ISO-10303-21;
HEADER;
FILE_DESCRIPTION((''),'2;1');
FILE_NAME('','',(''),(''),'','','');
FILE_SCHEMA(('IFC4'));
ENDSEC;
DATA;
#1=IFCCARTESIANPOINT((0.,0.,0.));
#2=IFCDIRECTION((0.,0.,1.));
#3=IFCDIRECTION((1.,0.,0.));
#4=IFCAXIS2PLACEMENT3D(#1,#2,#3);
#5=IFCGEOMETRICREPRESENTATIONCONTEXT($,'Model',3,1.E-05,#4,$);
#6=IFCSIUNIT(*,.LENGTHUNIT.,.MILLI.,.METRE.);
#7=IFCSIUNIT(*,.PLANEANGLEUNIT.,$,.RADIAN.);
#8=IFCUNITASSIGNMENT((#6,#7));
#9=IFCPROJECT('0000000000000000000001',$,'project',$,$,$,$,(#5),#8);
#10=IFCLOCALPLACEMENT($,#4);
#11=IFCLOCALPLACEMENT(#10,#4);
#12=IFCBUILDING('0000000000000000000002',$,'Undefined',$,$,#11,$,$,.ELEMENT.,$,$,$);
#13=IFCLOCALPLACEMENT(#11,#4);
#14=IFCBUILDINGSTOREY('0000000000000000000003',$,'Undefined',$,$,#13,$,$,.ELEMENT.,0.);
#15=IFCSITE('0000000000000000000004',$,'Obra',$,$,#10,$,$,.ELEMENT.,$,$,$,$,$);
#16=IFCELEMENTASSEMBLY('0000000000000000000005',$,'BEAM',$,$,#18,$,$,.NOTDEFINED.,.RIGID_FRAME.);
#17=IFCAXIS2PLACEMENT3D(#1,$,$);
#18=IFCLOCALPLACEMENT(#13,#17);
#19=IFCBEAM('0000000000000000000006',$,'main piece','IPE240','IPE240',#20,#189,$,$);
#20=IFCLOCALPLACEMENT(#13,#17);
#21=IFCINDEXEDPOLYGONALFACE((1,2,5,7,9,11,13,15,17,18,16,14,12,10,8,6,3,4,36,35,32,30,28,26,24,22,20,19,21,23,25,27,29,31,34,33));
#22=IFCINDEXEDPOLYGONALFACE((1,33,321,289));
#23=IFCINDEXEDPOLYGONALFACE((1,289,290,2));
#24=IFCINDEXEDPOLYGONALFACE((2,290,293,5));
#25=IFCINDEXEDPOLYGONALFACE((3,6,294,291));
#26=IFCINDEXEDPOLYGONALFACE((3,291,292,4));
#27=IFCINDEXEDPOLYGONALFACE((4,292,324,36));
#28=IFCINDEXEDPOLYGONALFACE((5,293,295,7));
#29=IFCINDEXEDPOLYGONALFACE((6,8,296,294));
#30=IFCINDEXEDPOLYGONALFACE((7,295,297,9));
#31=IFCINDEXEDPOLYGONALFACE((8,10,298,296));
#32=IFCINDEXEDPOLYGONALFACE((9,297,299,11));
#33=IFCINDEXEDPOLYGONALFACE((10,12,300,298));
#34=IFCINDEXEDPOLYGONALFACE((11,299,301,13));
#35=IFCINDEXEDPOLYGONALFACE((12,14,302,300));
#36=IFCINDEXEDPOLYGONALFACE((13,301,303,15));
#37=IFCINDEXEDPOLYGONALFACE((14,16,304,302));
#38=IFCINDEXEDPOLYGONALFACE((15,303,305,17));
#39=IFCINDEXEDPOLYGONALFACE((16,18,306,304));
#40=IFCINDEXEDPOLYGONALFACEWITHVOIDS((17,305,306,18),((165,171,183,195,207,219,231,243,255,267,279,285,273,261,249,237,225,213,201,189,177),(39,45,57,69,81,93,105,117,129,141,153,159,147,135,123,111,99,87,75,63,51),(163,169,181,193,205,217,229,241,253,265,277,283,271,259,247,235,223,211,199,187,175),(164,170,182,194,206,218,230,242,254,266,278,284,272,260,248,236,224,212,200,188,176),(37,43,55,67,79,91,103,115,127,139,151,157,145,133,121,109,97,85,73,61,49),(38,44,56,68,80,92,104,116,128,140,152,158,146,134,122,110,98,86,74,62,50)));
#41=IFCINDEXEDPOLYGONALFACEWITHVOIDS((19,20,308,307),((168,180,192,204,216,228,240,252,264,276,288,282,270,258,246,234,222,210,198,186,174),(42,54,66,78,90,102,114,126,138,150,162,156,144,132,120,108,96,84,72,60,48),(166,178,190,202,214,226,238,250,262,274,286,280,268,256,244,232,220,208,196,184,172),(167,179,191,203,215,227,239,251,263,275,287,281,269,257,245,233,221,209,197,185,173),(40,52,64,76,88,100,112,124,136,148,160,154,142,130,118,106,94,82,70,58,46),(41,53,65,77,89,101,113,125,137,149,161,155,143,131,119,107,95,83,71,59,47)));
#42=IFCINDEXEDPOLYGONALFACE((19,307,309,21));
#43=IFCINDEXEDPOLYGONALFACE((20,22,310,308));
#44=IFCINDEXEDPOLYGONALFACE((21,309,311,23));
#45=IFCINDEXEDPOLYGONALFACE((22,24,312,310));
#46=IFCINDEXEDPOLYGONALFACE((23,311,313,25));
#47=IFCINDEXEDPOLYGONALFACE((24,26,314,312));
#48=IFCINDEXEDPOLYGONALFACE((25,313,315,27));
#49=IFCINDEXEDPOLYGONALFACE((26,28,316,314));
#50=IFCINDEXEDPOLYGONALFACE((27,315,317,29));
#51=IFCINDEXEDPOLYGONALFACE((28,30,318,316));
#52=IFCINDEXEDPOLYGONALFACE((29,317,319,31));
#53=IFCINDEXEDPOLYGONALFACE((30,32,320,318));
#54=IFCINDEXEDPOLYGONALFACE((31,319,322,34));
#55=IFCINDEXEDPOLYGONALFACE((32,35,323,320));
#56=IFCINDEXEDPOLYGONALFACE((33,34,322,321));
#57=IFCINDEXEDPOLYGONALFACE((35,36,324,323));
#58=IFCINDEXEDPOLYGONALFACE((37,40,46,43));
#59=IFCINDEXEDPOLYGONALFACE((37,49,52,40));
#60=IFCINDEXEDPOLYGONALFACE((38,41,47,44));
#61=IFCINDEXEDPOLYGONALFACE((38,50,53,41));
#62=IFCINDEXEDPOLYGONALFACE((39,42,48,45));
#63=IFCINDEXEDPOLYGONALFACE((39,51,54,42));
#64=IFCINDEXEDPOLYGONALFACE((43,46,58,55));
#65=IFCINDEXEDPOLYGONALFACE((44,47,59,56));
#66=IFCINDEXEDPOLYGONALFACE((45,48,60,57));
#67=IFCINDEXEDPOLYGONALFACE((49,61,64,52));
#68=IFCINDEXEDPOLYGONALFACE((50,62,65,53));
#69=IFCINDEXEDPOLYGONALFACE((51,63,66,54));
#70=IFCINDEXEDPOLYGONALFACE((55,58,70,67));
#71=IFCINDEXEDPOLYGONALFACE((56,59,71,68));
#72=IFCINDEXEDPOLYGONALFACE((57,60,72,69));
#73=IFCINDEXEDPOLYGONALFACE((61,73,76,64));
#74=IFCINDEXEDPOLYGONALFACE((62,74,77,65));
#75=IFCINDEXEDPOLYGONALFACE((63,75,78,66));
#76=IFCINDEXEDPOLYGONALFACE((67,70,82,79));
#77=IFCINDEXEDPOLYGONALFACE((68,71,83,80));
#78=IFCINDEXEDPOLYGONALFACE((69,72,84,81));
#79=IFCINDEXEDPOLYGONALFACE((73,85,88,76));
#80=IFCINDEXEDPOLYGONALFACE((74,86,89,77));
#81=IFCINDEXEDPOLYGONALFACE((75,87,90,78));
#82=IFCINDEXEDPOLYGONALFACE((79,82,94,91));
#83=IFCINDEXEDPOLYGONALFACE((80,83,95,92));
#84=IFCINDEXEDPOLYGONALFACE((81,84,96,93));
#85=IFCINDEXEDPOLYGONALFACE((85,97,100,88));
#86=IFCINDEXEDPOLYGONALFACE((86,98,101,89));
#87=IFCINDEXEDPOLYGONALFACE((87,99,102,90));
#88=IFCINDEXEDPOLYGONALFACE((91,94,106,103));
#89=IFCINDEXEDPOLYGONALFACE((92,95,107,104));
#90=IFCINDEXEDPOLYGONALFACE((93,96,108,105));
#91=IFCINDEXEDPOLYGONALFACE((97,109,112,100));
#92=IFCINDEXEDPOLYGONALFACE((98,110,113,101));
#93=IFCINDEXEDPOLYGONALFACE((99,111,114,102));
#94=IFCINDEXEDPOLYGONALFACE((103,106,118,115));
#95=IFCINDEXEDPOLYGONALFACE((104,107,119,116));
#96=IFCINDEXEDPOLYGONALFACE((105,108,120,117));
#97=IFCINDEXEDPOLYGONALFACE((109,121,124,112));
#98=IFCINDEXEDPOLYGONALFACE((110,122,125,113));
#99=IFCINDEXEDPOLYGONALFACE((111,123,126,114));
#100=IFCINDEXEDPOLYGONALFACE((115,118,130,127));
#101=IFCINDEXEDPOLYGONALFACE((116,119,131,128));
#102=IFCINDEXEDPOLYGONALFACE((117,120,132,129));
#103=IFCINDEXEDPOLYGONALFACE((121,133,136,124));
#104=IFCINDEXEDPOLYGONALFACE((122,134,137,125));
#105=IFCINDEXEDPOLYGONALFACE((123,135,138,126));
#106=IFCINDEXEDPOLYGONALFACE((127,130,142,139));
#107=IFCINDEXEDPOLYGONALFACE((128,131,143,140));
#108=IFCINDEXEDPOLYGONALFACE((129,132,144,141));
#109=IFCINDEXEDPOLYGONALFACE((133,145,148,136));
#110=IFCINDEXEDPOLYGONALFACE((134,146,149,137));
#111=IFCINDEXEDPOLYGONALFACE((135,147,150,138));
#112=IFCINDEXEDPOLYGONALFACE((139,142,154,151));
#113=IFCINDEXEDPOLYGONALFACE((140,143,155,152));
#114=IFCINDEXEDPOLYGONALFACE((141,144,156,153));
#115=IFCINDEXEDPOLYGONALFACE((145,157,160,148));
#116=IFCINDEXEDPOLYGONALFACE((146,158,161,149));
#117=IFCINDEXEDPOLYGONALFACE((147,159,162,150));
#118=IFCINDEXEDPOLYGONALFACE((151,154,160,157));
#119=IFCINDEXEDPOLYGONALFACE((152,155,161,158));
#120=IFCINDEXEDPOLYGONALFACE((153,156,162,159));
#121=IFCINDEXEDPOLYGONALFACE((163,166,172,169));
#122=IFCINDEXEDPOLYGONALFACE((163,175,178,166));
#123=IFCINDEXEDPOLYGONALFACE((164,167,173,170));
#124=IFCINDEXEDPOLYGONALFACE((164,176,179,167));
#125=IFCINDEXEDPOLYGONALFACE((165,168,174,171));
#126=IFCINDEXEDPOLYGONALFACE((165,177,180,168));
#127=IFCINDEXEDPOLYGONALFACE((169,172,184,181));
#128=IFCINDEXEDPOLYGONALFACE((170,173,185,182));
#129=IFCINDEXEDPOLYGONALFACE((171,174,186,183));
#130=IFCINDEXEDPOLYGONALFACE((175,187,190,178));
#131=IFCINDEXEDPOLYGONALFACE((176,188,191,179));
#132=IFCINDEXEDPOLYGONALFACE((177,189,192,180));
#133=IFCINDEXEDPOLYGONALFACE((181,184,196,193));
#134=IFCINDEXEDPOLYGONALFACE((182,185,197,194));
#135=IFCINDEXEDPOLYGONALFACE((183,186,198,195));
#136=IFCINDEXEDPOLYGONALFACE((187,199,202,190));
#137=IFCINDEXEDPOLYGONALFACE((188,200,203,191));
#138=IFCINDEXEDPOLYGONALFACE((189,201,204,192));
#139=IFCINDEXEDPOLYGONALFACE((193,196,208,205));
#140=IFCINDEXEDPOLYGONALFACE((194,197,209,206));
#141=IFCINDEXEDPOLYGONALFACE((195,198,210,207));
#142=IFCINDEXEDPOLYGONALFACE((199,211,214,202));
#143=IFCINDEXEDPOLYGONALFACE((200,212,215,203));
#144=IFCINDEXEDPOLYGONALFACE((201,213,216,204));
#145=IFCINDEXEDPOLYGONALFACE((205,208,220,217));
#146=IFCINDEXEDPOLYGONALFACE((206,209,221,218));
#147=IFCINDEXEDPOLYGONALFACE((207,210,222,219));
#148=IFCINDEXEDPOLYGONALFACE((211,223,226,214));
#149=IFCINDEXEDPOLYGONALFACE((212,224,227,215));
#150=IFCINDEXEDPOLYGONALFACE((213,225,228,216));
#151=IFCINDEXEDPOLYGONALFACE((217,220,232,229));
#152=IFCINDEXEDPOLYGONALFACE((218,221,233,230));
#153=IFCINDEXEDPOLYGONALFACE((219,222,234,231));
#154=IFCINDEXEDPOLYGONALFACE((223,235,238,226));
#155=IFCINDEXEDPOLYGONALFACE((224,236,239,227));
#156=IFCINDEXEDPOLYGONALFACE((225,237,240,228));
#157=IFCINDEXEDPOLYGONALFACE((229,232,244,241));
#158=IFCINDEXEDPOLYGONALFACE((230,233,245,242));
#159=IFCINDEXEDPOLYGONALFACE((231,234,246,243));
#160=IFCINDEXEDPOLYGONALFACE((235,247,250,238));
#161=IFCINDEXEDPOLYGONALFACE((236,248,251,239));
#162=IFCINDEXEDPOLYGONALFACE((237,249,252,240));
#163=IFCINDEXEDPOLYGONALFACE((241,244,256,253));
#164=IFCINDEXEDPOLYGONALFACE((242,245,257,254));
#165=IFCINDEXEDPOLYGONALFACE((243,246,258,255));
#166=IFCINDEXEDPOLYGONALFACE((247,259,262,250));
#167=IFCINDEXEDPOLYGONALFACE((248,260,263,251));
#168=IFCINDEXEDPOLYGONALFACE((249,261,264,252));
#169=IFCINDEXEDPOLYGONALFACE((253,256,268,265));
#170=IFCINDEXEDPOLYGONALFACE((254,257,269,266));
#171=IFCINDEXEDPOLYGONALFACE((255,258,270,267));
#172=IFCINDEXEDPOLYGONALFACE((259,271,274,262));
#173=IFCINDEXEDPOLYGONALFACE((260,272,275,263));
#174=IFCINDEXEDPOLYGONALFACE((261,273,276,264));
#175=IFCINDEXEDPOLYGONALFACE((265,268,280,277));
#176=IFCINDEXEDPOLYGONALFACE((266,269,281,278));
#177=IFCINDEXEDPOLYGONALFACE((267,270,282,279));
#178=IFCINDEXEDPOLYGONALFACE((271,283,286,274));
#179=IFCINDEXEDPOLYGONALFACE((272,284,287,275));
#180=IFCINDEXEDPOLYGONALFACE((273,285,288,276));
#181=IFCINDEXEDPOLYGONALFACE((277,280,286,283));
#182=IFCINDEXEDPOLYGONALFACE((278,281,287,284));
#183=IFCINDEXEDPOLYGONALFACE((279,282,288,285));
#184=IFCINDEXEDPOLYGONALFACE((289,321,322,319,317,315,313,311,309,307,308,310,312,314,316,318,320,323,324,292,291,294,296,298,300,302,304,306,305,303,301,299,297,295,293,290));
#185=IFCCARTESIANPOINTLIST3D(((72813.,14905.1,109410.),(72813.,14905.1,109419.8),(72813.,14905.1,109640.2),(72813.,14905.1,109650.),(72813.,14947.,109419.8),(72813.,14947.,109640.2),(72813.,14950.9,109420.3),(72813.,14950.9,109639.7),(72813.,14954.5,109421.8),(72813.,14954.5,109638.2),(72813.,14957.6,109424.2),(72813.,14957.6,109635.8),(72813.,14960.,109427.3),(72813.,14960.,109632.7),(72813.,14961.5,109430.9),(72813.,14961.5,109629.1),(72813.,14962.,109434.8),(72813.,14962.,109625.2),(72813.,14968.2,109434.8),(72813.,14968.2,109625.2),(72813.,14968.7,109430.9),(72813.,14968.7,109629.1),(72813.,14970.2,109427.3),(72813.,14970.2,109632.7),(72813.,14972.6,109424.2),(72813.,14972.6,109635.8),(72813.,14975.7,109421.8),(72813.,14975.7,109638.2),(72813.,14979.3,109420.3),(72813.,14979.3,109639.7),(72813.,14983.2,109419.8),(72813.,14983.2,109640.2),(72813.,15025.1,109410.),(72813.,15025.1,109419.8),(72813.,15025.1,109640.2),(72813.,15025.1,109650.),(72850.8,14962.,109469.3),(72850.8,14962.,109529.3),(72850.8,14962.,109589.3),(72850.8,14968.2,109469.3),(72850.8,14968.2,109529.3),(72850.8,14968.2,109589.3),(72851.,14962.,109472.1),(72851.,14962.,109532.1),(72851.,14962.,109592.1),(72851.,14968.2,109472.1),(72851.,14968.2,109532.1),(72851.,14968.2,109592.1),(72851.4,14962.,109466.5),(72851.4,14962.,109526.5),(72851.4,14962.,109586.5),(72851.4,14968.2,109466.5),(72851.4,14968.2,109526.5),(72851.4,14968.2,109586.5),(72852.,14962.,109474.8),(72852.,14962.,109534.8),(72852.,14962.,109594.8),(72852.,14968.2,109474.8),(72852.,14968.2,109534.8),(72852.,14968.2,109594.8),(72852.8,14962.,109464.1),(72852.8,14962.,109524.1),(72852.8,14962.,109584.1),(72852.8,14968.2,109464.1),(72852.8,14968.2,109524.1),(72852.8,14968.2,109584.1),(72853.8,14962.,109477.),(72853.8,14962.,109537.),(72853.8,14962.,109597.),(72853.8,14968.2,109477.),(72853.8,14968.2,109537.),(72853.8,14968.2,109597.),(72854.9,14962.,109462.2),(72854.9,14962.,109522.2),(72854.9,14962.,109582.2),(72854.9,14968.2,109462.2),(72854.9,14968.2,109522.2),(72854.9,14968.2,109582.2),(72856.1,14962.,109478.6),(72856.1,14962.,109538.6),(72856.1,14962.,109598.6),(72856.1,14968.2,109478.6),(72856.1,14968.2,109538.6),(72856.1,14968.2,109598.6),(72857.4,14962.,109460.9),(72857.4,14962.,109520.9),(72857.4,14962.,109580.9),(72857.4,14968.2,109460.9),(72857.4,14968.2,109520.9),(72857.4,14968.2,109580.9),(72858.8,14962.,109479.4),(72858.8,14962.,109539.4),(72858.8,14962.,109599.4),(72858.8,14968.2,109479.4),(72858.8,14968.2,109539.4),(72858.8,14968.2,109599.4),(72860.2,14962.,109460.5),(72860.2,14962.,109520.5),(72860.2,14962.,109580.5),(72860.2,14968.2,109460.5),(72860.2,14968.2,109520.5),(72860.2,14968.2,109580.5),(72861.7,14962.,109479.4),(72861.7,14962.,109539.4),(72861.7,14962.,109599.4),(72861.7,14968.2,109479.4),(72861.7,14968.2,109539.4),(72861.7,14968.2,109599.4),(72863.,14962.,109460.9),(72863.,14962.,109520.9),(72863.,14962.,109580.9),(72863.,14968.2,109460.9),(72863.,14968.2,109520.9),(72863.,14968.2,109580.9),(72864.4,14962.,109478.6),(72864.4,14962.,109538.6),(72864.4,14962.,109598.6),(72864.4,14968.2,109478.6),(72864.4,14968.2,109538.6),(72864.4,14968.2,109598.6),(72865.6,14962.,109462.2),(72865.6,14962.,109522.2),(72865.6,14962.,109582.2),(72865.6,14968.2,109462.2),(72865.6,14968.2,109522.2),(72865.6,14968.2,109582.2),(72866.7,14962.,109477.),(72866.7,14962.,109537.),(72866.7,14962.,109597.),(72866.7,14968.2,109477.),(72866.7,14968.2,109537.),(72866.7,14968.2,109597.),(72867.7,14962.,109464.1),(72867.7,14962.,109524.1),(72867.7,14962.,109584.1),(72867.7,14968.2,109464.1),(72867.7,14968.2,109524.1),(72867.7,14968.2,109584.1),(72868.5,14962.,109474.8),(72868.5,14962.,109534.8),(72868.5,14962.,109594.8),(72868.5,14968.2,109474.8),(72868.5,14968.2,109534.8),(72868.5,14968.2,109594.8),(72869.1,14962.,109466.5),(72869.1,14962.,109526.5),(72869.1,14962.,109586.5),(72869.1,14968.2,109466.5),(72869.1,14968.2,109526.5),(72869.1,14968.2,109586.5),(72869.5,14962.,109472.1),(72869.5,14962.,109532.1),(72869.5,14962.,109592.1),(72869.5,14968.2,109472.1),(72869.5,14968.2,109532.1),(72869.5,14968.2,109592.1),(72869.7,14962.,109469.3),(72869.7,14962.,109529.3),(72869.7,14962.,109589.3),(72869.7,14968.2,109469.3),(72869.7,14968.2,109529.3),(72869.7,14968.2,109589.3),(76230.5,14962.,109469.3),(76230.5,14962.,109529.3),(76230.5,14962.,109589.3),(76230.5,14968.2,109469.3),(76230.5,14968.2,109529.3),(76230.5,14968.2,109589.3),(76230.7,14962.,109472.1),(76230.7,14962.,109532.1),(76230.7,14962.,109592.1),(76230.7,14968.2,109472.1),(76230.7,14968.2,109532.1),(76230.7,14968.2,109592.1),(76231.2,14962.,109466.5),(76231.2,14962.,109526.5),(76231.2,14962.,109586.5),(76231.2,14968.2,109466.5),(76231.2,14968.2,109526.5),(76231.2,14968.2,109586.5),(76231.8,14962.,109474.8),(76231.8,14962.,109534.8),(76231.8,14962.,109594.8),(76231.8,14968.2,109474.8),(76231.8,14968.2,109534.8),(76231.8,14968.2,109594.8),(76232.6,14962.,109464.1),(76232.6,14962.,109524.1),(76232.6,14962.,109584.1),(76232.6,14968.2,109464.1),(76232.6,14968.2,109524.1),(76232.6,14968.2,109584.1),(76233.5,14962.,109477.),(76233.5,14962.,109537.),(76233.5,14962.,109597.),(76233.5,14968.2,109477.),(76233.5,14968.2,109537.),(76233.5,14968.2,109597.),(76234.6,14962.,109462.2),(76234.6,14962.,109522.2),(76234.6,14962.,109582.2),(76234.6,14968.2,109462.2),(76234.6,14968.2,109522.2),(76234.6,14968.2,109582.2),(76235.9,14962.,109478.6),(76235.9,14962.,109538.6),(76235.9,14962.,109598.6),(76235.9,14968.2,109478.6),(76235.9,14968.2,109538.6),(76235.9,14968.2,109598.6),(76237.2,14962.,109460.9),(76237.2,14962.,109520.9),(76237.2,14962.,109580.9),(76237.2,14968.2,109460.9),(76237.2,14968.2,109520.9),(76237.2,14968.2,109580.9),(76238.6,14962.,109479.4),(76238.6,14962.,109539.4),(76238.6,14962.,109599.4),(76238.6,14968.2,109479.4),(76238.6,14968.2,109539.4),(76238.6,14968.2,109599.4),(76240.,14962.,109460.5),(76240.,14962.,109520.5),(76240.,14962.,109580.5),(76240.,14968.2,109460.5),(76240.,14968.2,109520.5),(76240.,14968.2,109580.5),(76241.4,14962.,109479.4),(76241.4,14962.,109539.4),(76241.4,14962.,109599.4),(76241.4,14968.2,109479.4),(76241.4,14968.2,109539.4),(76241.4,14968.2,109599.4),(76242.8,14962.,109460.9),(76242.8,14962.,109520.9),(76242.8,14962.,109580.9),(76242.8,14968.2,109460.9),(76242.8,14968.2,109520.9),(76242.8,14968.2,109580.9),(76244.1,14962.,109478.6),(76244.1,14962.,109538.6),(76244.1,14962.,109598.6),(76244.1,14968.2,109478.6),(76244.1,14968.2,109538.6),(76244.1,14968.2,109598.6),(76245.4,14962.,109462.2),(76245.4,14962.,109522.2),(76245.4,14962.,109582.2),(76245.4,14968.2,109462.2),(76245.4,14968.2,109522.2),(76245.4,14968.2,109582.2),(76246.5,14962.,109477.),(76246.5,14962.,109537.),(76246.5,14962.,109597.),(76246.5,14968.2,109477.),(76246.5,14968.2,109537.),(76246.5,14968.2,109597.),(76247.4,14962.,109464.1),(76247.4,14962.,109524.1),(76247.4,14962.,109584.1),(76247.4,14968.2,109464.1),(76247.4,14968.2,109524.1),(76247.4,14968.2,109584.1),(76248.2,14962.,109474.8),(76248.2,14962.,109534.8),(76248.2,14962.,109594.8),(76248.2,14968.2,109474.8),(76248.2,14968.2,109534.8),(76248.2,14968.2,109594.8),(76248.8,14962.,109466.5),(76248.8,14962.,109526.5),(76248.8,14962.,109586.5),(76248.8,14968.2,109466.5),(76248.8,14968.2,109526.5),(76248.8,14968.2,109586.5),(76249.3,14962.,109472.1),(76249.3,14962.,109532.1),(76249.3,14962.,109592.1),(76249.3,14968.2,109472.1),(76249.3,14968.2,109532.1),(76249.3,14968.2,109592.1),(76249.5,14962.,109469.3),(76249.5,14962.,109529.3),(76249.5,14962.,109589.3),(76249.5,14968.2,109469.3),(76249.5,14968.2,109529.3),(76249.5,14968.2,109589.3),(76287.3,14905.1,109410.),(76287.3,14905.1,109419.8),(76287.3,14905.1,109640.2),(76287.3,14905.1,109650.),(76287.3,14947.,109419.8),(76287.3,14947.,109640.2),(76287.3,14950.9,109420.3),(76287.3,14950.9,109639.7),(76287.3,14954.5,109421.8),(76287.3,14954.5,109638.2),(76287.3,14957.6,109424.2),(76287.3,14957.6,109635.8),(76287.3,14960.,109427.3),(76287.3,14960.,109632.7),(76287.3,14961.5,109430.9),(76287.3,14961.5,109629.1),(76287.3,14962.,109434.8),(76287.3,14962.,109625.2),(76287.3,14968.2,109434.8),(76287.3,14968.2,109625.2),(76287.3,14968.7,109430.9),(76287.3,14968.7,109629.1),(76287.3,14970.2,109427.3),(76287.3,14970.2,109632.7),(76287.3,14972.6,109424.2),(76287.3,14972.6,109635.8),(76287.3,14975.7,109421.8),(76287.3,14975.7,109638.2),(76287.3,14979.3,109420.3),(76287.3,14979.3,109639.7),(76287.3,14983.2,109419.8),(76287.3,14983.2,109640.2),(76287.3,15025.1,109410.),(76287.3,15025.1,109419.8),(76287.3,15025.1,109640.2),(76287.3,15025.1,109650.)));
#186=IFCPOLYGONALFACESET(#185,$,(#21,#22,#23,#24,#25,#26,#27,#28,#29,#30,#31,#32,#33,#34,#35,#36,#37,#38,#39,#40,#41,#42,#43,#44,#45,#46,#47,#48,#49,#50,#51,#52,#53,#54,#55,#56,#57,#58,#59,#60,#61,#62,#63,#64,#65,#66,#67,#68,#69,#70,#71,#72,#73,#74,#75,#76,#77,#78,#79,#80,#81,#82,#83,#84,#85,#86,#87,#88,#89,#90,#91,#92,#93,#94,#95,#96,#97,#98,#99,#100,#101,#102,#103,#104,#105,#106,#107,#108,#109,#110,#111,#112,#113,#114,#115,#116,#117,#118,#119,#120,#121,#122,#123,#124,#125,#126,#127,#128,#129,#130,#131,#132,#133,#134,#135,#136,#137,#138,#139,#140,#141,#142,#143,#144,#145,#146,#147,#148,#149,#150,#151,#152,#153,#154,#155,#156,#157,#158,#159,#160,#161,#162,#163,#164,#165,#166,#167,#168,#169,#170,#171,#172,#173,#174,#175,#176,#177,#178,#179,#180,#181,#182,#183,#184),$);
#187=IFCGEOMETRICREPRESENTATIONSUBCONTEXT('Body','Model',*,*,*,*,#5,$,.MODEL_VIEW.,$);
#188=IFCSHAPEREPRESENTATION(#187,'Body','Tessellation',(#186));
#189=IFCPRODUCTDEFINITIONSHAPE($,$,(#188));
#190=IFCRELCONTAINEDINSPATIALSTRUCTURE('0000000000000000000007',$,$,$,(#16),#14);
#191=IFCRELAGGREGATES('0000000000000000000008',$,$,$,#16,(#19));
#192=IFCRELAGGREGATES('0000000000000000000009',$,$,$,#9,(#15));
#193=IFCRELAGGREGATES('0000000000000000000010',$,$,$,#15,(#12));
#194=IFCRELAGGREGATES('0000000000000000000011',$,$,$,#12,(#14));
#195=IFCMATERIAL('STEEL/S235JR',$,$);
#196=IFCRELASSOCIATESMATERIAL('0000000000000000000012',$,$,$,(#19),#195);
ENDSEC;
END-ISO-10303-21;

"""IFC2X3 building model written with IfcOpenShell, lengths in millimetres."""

from ifc_helpers import new_model, si_unit, frame, origin_with_axes, origin_2d_with_axis, place, context, subcontext, project, spatial, circle, i_section, extrude, source, transform, mapped, material, element, aggregate, save


model = new_model("IFC2X3")

# Units and contexts
model_context = context("Model", 3, precision=1e-05, world=origin_with_axes())
body_context = subcontext(model_context, "Body", "Model", "MODEL_VIEW")
ifc_project = project(units=[si_unit("LENGTHUNIT", "METRE", prefix="MILLI"), si_unit("PLANEANGLEUNIT", "RADIAN")], contexts=[model_context])

# Site, building, storey
site_placement = place(None, origin_with_axes())
site = spatial("IfcSite", under=ifc_project, at=site_placement, Name="Obra", CompositionType="ELEMENT")
building_placement = place(site_placement, origin_with_axes())
building = spatial("IfcBuilding", under=site, at=building_placement, Name="Undefined", CompositionType="ELEMENT")
storey_placement = place(building_placement, origin_with_axes())
storey = spatial("IfcBuildingStorey", under=building, at=storey_placement, Name="Undefined", CompositionType="ELEMENT", Elevation=0.0)

# Element assembly, beam, openings
ifc_material_1 = material(Name="STEEL/S235JR")
shared_shape_1 = source(origin_with_axes(), body_context, "Body", "SweptSolid", [
    extrude(circle(Radius=9.5, at=origin_2d_with_axis()), frame((0.0, -3.2, 0.0), z_axis=(0.0, 1.0, 0.0), x_axis=(1.0, 0.0, 0.0)), (0.0, 0.0, 1.0), 6.4),
])
assembly_1_placement = place(storey_placement, origin_with_axes())
assembly_1 = element("IfcElementAssembly", 1, at=assembly_1_placement, inside=storey, Name="BEAM", AssemblyPlace="NOTDEFINED", PredefinedType="RIGID_FRAME")
beam_1_placement = place(assembly_1_placement, frame((72813.0, 14965.1, 109530.0), z_axis=(0.0, 0.0, 1.0), x_axis=(1.0, 0.0, 0.0)))
beam_1 = element("IfcBeam", 2, at=beam_1_placement, material=ifc_material_1, Name="main piece", Description="IPE240", ObjectType="IPE240", context=body_context, shape_type="SweptSolid", body=[
    extrude(i_section(OverallWidth=120.0, OverallDepth=240.0, WebThickness=6.2, FlangeThickness=9.8, FilletRadius=15.0, at=origin_2d_with_axis()), frame((3474.3, 0.0, 0.0), z_axis=(-1.0, 0.0, 0.0), x_axis=(0.0, -1.0, 0.0)), (0.0, 0.0, 1.0), 3474.3),
])
opening_1_placement = place(assembly_1_placement, frame((76290.0, 14965.1, 109650.0), z_axis=(-1.0, 0.0, 0.0), x_axis=(0.0, 0.0, -1.0)))
element("IfcOpeningElement", 3, at=opening_1_placement, cuts=beam_1, ObjectType="Opening", context=body_context, shape_type="MappedRepresentation", body=[
    mapped(shared_shape_1, transform((60.0, 0.0, 50.0))),
    mapped(shared_shape_1, transform((120.0, 0.0, 50.0))),
    mapped(shared_shape_1, transform((180.0, 0.0, 50.0))),
])
opening_2_placement = place(assembly_1_placement, frame((72810.2, 14965.1, 109650.0), z_axis=(1.0, 0.0, 0.0), x_axis=(0.0, 0.0, -1.0)))
element("IfcOpeningElement", 4, at=opening_2_placement, cuts=beam_1, ObjectType="Opening", context=body_context, shape_type="MappedRepresentation", body=[
    mapped(shared_shape_1, transform((60.0, 0.0, 50.0))),
    mapped(shared_shape_1, transform((120.0, 0.0, 50.0))),
    mapped(shared_shape_1, transform((180.0, 0.0, 50.0))),
])

aggregate(assembly_1, [beam_1])

save(model, "model.ifc")
